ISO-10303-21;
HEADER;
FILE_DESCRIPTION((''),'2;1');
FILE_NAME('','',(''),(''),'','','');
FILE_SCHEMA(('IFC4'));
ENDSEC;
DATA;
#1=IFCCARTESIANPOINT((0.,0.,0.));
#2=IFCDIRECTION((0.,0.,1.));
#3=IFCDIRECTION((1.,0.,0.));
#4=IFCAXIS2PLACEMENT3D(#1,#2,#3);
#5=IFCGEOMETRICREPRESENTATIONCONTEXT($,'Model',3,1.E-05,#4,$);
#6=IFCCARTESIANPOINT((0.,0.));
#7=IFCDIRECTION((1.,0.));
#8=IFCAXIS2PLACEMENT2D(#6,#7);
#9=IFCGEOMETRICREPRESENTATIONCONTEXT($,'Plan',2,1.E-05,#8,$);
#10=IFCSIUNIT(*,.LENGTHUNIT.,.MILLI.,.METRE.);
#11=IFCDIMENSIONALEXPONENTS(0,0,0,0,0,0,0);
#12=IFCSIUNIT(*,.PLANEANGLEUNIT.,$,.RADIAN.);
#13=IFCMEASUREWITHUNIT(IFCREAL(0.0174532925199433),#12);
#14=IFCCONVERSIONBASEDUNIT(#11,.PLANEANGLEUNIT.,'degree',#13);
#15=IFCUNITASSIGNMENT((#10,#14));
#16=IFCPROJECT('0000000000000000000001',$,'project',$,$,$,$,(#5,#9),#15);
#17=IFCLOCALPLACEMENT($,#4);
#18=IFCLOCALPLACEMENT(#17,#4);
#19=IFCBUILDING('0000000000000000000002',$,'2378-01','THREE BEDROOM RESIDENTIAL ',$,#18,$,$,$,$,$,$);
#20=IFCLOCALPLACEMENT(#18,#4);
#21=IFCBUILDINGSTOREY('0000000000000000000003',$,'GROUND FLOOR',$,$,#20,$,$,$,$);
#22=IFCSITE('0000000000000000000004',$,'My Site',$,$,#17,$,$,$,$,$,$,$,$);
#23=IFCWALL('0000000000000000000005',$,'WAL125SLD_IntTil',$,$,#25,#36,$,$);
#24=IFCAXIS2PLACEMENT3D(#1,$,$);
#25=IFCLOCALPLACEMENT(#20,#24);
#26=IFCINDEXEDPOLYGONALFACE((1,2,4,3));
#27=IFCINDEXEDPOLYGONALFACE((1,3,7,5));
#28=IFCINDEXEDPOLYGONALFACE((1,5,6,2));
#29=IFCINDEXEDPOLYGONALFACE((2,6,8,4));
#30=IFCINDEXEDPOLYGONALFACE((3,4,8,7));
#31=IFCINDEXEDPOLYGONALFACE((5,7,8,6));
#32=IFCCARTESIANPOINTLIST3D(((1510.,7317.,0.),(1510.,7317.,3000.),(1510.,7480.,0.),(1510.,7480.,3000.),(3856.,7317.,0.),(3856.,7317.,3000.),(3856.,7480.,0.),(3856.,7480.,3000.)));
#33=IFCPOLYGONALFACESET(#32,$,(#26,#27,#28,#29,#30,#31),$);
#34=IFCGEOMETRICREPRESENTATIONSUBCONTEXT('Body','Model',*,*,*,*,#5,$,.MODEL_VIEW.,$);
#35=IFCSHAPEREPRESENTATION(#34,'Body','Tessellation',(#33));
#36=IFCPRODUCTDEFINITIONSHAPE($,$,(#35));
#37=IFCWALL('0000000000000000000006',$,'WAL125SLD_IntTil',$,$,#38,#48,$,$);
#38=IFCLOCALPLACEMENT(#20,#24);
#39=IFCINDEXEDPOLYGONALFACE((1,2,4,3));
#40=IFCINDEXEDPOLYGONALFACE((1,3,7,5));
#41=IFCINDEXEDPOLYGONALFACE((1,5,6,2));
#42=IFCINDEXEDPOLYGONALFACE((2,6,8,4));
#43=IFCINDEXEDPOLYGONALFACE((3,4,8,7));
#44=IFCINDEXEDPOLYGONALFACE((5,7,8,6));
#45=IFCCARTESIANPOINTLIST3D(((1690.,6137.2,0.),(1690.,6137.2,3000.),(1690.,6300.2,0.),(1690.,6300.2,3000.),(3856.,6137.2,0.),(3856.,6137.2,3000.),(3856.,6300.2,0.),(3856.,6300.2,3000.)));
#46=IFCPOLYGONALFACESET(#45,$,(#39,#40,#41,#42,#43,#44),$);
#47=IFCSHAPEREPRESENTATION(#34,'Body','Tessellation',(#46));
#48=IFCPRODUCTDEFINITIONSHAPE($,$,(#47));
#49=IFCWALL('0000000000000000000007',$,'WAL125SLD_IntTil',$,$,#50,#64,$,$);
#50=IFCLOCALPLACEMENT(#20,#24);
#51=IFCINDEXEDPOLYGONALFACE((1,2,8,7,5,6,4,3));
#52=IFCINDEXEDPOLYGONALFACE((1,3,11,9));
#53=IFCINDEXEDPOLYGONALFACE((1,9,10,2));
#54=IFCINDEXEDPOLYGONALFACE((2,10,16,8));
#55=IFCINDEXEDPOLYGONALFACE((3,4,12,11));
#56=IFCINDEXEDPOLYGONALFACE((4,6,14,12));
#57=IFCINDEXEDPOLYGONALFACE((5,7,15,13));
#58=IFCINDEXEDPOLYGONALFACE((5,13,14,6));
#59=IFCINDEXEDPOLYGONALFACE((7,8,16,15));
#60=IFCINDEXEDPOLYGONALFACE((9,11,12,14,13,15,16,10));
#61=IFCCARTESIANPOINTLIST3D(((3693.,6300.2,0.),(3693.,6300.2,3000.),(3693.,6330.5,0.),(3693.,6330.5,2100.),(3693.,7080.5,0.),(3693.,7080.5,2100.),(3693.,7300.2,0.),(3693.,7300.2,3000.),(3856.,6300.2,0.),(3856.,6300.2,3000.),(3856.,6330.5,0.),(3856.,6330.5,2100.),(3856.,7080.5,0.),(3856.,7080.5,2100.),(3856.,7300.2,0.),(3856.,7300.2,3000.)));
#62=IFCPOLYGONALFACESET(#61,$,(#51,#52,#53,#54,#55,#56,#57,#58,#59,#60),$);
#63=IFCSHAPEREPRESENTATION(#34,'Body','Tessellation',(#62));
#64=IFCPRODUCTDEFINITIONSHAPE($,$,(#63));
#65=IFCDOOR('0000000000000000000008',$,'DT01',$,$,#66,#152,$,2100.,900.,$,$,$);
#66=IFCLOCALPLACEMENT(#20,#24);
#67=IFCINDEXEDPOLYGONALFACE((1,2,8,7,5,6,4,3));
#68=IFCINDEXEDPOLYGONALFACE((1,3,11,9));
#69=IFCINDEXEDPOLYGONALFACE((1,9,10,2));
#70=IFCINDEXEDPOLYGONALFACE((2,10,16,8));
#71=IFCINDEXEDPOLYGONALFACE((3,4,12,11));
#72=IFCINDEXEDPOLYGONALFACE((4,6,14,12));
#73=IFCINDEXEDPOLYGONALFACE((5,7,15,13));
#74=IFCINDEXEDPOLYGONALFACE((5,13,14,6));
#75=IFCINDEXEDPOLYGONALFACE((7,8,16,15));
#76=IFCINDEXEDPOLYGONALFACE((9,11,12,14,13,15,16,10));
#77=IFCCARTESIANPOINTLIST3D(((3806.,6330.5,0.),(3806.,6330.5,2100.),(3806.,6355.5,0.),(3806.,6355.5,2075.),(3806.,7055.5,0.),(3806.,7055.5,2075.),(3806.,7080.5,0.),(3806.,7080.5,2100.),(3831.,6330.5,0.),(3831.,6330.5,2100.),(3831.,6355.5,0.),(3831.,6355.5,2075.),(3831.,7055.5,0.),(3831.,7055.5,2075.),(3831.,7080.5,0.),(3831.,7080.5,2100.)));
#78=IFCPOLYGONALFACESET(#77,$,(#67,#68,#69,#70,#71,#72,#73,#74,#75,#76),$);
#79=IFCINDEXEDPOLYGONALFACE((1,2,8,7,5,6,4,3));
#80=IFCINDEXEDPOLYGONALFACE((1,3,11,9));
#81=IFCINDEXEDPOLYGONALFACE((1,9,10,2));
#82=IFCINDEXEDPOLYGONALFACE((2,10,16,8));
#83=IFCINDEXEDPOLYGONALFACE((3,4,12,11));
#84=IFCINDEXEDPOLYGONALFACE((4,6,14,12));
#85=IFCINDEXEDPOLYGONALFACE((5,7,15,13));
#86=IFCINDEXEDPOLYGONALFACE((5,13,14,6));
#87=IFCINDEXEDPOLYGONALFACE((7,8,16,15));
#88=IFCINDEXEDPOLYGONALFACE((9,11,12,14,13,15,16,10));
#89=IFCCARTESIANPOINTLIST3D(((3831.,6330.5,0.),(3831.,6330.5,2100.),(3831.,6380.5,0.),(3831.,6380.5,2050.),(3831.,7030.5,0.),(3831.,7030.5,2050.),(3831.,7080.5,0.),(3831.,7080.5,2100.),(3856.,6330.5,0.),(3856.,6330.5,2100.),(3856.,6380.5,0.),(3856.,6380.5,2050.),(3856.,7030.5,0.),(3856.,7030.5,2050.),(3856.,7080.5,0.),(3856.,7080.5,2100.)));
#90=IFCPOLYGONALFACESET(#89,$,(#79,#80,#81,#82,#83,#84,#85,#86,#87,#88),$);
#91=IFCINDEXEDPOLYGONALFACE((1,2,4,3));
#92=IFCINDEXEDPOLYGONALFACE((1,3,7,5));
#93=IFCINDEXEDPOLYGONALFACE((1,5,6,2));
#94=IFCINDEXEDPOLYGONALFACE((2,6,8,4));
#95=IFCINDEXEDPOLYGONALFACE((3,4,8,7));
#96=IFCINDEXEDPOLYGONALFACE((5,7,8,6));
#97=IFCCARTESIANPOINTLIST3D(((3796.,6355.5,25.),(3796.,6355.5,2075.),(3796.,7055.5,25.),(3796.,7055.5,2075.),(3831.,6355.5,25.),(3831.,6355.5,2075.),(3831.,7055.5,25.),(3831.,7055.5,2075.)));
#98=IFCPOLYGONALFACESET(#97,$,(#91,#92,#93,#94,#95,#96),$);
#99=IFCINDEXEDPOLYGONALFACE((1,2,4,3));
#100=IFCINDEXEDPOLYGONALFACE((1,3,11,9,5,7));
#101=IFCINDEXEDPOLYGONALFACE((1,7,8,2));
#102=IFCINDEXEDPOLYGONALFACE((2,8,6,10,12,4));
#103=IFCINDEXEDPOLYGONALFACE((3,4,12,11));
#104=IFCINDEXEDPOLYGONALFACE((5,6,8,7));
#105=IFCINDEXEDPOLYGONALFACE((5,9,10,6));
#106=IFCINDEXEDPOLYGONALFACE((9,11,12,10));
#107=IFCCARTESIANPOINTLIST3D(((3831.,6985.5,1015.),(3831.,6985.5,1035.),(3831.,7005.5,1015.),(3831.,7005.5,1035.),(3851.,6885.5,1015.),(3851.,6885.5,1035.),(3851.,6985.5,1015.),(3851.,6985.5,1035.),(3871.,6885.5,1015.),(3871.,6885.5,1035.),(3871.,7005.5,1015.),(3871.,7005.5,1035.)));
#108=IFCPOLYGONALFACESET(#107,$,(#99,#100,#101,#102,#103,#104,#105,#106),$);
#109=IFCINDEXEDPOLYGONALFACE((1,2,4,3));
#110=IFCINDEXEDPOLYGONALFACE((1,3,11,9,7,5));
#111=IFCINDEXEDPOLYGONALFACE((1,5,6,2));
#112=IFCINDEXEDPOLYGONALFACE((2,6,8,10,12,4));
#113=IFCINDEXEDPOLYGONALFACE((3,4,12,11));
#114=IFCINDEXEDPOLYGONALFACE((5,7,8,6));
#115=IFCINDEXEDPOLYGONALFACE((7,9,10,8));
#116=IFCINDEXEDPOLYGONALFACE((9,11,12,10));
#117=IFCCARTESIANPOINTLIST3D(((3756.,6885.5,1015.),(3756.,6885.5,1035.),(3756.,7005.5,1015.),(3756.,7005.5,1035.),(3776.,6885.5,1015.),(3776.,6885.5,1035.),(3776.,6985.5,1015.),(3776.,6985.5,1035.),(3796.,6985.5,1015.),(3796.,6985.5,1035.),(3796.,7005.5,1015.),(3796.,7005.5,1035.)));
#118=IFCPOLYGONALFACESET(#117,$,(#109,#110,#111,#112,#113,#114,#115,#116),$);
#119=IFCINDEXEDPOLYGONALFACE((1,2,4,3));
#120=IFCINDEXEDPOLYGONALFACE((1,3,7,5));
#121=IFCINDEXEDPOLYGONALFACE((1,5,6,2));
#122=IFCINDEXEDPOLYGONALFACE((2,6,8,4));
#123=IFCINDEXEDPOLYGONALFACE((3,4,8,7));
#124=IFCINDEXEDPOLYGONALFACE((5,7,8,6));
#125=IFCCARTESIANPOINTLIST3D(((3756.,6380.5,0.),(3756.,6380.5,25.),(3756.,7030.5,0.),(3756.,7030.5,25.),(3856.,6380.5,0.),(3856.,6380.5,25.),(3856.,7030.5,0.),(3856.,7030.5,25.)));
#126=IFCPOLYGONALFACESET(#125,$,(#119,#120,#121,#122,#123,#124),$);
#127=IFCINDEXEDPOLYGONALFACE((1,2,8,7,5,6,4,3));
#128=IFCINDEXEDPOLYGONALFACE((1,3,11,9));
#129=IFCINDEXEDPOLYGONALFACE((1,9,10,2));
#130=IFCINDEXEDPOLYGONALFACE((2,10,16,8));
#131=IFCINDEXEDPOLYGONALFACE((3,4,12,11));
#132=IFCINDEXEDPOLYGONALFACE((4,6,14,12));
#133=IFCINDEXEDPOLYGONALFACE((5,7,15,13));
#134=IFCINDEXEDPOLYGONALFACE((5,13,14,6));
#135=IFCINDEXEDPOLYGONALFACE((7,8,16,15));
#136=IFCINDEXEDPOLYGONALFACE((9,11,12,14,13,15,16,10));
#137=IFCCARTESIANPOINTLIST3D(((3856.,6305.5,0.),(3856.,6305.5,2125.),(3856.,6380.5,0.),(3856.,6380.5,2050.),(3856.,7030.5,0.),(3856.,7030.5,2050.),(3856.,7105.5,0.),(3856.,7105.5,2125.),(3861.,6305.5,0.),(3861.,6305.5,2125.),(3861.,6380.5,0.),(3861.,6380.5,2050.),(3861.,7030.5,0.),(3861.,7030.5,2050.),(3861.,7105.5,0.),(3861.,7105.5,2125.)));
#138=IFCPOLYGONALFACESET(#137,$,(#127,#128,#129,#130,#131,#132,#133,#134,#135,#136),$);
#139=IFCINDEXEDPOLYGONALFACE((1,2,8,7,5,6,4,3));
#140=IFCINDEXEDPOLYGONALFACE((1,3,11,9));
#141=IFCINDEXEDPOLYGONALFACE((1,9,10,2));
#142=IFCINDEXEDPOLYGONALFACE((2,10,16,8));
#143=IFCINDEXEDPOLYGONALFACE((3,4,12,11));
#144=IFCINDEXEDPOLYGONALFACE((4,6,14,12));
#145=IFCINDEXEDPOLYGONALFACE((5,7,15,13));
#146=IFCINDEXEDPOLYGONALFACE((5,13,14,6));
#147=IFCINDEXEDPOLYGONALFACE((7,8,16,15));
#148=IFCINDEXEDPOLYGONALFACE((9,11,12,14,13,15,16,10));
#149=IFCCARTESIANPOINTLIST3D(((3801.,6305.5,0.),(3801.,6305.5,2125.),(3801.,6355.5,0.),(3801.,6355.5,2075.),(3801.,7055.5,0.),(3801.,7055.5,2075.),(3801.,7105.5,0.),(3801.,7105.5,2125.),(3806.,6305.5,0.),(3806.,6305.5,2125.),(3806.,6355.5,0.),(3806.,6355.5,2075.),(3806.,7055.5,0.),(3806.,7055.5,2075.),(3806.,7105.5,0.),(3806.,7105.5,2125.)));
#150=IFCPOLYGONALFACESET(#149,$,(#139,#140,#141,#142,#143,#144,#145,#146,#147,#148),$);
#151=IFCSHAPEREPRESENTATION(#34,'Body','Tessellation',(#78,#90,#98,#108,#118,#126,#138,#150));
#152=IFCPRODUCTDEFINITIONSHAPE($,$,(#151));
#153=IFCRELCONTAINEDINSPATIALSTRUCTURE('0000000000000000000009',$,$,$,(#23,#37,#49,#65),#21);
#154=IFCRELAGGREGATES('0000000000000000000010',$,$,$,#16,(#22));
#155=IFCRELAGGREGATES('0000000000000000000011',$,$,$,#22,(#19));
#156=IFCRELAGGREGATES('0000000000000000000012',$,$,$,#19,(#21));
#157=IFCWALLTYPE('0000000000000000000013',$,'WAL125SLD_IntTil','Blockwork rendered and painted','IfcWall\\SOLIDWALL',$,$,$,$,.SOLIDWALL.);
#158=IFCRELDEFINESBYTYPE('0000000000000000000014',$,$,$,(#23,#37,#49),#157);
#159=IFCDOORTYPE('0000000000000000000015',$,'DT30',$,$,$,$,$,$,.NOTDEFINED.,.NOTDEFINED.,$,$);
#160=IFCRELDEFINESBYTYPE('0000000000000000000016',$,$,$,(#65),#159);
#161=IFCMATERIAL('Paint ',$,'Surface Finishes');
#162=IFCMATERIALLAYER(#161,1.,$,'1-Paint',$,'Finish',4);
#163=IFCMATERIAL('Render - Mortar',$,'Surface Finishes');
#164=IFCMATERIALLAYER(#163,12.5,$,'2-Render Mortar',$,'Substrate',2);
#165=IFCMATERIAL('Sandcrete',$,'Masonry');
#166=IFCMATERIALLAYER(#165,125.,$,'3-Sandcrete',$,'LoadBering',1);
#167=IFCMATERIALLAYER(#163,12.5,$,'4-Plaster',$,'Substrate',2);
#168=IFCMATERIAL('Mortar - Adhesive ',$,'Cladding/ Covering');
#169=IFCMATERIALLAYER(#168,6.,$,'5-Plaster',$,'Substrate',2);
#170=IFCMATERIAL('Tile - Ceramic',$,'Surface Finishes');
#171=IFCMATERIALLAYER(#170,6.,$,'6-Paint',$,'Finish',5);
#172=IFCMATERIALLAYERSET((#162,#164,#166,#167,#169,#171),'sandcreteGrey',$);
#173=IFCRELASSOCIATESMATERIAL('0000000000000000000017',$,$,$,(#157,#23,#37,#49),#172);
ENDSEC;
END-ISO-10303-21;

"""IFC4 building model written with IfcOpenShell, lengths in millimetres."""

from ifc_helpers import new_model, entity, si_unit, converted_unit, frame, origin_with_axes, origin_2d_with_axis, place, context, subcontext, project, spatial, line, indexed_curve, outline, extrude, shape, source, transform, mapped, material, layer, layer_set, layer_usage, type_object, type_shapes, element, fill, save


model = new_model("IFC4")

# Units and contexts
model_context = context("Model", 3, precision=1e-05, world=origin_with_axes())
plan_context = context("Plan", 2, precision=1e-05, world=origin_2d_with_axis())
body_context_1 = subcontext(model_context, "Body", "Model", "MODEL_VIEW")
body_context_2 = subcontext(plan_context, "Body", "Plan", "PLAN_VIEW")
ifc_project = project(units=[si_unit("LENGTHUNIT", "METRE", prefix="MILLI"), converted_unit("PLANEANGLEUNIT", "degree", entity("IfcReal", 0.0174532925199433), si_unit("PLANEANGLEUNIT", "RADIAN"), dimensions=[0, 0, 0, 0, 0, 0, 0])], contexts=[model_context, plan_context])

# Site, building, storey
site_placement = place(None, origin_with_axes())
site = spatial("IfcSite", under=ifc_project, at=site_placement, Name="My Site")
building_placement = place(site_placement, origin_with_axes())
building = spatial("IfcBuilding", under=site, at=building_placement, Name="2378-01", Description="THREE BEDROOM RESIDENTIAL ")
storey_placement = place(building_placement, origin_with_axes())
storey = spatial("IfcBuildingStorey", under=building, at=storey_placement, Name="GROUND FLOOR")

# Walls
ifc_material_1 = material(Name="Paint ", Category="Surface Finishes")
ifc_layer_1 = layer(ifc_material_1, 1.0, Name="1-Paint", Category="Finish", Priority=4)
ifc_material_2 = material(Name="Render - Mortar", Category="Surface Finishes")
ifc_layer_2 = layer(ifc_material_2, 12.5, Name="2-Render Mortar", Category="Substrate", Priority=2)
ifc_material_3 = material(Name="Sandcrete", Category="Masonry")
ifc_layer_3 = layer(ifc_material_3, 125.0, Name="3-Sandcrete", Category="LoadBering", Priority=1)
ifc_layer_4 = layer(ifc_material_2, 12.5, Name="4-Plaster", Category="Substrate", Priority=2)
ifc_material_4 = material(Name="Mortar - Adhesive ", Category="Cladding/ Covering")
ifc_layer_5 = layer(ifc_material_4, 6.0, Name="5-Plaster", Category="Substrate", Priority=2)
ifc_material_5 = material(Name="Tile - Ceramic", Category="Surface Finishes")
ifc_layer_6 = layer(ifc_material_5, 6.0, Name="6-Paint", Category="Finish", Priority=5)
ifc_layer_set_1 = layer_set([ifc_layer_1, ifc_layer_2, ifc_layer_3, ifc_layer_4, ifc_layer_5, ifc_layer_6], Name="sandcreteGrey")
ifc_layer_usage_1 = layer_usage(ifc_layer_set_1, "AXIS2", "POSITIVE", 0.0)
wall_type_1 = type_object("IfcWallType", Name="WAL125SLD_IntTil", Description="Blockwork rendered and painted", ApplicableOccurrence="IfcWall\\SOLIDWALL", PredefinedType="SOLIDWALL", material=ifc_layer_set_1)
wall_1_placement = place(storey_placement, frame((3856.0, 7480.0, 0.0), z_axis=(0.0, 0.0, 1.0), x_axis=(-1.0, 0.0, 0.0)))
element("IfcWall", 1, at=wall_1_placement, inside=storey, type_object=wall_type_1, material=ifc_layer_usage_1, Name="WAL125SLD_IntTil", context=body_context_1, shape_type="SweptSolid", body=[
    extrude(outline(indexed_curve([(0.0, 0.0), (0.0, 163.0), (2346.0, 163.0), (2346.0, 0.0), (0.0, 0.0)], self_intersect=False)), origin_with_axes(), (0.0, 0.0, 1.0), 3000.0),
])
ifc_layer_usage_2 = layer_usage(ifc_layer_set_1, "AXIS2", "POSITIVE", 0.0)
wall_2_placement = place(storey_placement, frame((1690.0, 6137.2, 0.0), z_axis=(0.0, 0.0, 1.0), x_axis=(1.0, 0.0, 0.0)))
element("IfcWall", 2, at=wall_2_placement, inside=storey, type_object=wall_type_1, material=ifc_layer_usage_2, Name="WAL125SLD_IntTil", context=body_context_1, shape_type="SweptSolid", body=[
    extrude(outline(indexed_curve([(0.0, 0.0), (0.0, 163.0), (2166.0, 163.0), (2166.0, 0.0), (0.0, 0.0)], self_intersect=False)), origin_with_axes(), (0.0, 0.0, 1.0), 3000.0),
])

# Wall, opening, door
ifc_layer_usage_3 = layer_usage(ifc_layer_set_1, "AXIS2", "POSITIVE", 0.0)
wall_3_placement = place(storey_placement, frame((3856.0, 6300.2, 0.0), z_axis=(0.0, 0.0, 1.0), x_axis=(0.0, 1.0, 0.0)))
wall_3 = element("IfcWall", 3, at=wall_3_placement, inside=storey, type_object=wall_type_1, material=ifc_layer_usage_3, Name="WAL125SLD_IntTil", context=body_context_1, shape_type="SweptSolid", body=[
    extrude(outline(indexed_curve([(0.0, 0.0), (0.0, 163.0), (1000.0, 163.0), (1000.0, 0.0), (0.0, 0.0)], self_intersect=False)), origin_with_axes(), (0.0, 0.0, 1.0), 3000.0),
])
shared_shape_1 = source(origin_with_axes(), body_context_1, "Body", "SweptSolid", [
    extrude(outline(indexed_curve([(0.0, 0.0), (750.0, 0.0), (750.0, 2100.0), (0.0, 2100.0)], segments=[line(1, 2, 3, 4, 1)])), frame((0.0, -100.0, 0.0), z_axis=(0.0, -1.0, 0.0), x_axis=(1.0, 0.0, 0.0)), (0.0, 0.0, -1.0), 380.0),
])
opening_1_placement = place(wall_3_placement, frame((30.4, 0.0, 0.0), z_axis=(0.0, 0.0, 1.0), x_axis=(1.0, 0.0, 0.0)))
opening_1 = element("IfcOpeningElement", 4, at=opening_1_placement, cuts=wall_3, PredefinedType="OPENING", context=body_context_1, shape_type="MappedRepresentation", body=[
    mapped(shared_shape_1, transform((0.0, 0.0, 0.0), x_axis=(1.0, 0.0, 0.0), y_axis=(0.0, 1.0, 0.0), z_axis=(0.0, 0.0, 1.0), scale=1.0)),
])
door_type = type_object("IfcDoorType", Name="DT30", OperationType="NOTDEFINED", PredefinedType="NOTDEFINED")
shared_shape_2 = source(origin_with_axes(), body_context_1, "Body", "SweptSolid", [
    extrude(outline(indexed_curve([(0.0, 0.0), (0.0, 2100.0), (750.0, 2100.0), (750.0, 0.0), (725.0, 0.0), (725.0, 2075.0), (25.0, 2075.0), (25.0, 0.0)], segments=[line(1, 2, 3, 4, 5, 6, 7, 8, 1)])), frame((0.0, 25.0, 0.0), z_axis=(0.0, -1.0, 0.0), x_axis=(1.0, 0.0, 0.0)), (0.0, 0.0, -1.0), 25.0),
    extrude(outline(indexed_curve([(0.0, 0.0), (0.0, 2100.0), (750.0, 2100.0), (750.0, 0.0), (700.0, 0.0), (700.0, 2050.0), (50.0, 2050.0), (50.0, 0.0)], segments=[line(1, 2, 3, 4, 5, 6, 7, 8, 1)])), frame((0.0, 0.0, 0.0), z_axis=(0.0, -1.0, 0.0), x_axis=(1.0, 0.0, 0.0)), (0.0, 0.0, -1.0), 25.0),
    extrude(outline(indexed_curve([(0.0, 0.0), (700.0, 0.0), (700.0, 35.0), (0.0, 35.0)], segments=[line(1, 2, 3, 4, 1)])), frame((25.0, 25.0, 25.0), z_axis=(0.0, 0.0, 1.0), x_axis=(1.0, 0.0, 0.0)), (0.0, 0.0, 1.0), 2050.0),
    extrude(outline(indexed_curve([(0.0, 0.0), (0.0, -40.0), (-120.0, -40.0), (-120.0, -20.0), (-20.0, -20.0), (-20.0, 0.0)], segments=[line(1, 2, 3, 4, 5, 6, 1)])), frame((675.0, 25.0, 1015.0), z_axis=(0.0, 0.0, 1.0), x_axis=(1.0, 0.0, 0.0)), (0.0, 0.0, 1.0), 20.0),
    extrude(outline(indexed_curve([(0.0, 0.0), (0.0, 40.0), (-120.0, 40.0), (-120.0, 20.0), (-20.0, 20.0), (-20.0, 0.0)], segments=[line(1, 2, 3, 4, 5, 6, 1)])), frame((675.0, 60.0, 1015.0), z_axis=(0.0, 0.0, 1.0), x_axis=(1.0, 0.0, 0.0)), (0.0, 0.0, 1.0), 20.0),
    extrude(outline(indexed_curve([(0.0, 0.0), (650.0, 0.0), (650.0, 100.0), (0.0, 100.0)], segments=[line(1, 2, 3, 4, 1)])), frame((50.0, 0.0, 0.0), z_axis=(0.0, 0.0, 1.0), x_axis=(1.0, 0.0, 0.0)), (0.0, 0.0, 1.0), 25.0),
    extrude(outline(indexed_curve([(0.0, 0.0), (0.0, 2125.0), (800.0, 2125.0), (800.0, 0.0), (725.0, 0.0), (725.0, 2050.0), (75.0, 2050.0), (75.0, 0.0)], segments=[line(1, 2, 3, 4, 5, 6, 7, 8, 1)])), frame((-25.0, -5.0, 0.0), z_axis=(0.0, -1.0, 0.0), x_axis=(1.0, 0.0, 0.0)), (0.0, 0.0, -1.0), 5.0),
    extrude(outline(indexed_curve([(0.0, 0.0), (0.0, 2125.0), (800.0, 2125.0), (800.0, 0.0), (750.0, 0.0), (750.0, 2075.0), (50.0, 2075.0), (50.0, 0.0)], segments=[line(1, 2, 3, 4, 5, 6, 7, 8, 1)])), frame((-25.0, 50.0, 0.0), z_axis=(0.0, -1.0, 0.0), x_axis=(1.0, 0.0, 0.0)), (0.0, 0.0, -1.0), 5.0),
])
shared_shape_3 = source(origin_with_axes(), body_context_2, "Body", "Curve2D", [
    entity("IfcIndexedPolyCurve", entity("IfcCartesianPointList2D", [[0.0, 0.0], [0.0, 50.0], [25.0, 50.0], [25.0, 25.0], [50.0, 25.0], [50.0, 0.0]]), [entity("IfcLineIndex", [1, 2, 3, 4, 5, 6, 1])]),
    entity("IfcIndexedPolyCurve", entity("IfcCartesianPointList2D", [[750.0, 0.0], [750.0, 50.0], [725.0, 50.0], [725.0, 25.0], [700.0, 25.0], [700.0, 0.0]]), [entity("IfcLineIndex", [1, 2, 3, 4, 5, 6, 1])]),
    entity("IfcTrimmedCurve", entity("IfcEllipse", entity("IfcAxis2Placement2D", entity("IfcCartesianPoint", [60.0, 50.0]), entity("IfcDirection", [1.0, 0.0])), 665.0, 700.0), [entity("IfcCartesianPoint", [725.0, 50.0])], [entity("IfcCartesianPoint", [60.0, 750.0])], True, "CARTESIAN"),
    entity("IfcIndexedPolyCurve", entity("IfcCartesianPointList2D", [[25.0, 50.0], [60.0, 50.0], [60.0, 750.0], [25.0, 750.0]]), [entity("IfcLineIndex", [1, 2, 3, 4, 1])]),
])
type_shapes(door_type, [shared_shape_2, shared_shape_3])
door_placement = place(opening_1_placement, frame((0.0, 0.0, 0.0), z_axis=(0.0, 0.0, 1.0), x_axis=(1.0, 0.0, 0.0)))
door = element("IfcDoor", 5, at=door_placement, inside=storey, type_object=door_type, Name="DT01", OverallHeight=2100.0, OverallWidth=900.0, shapes=[
    shape(body_context_1, "Body", "MappedRepresentation", [mapped(shared_shape_2, transform((0.0, 0.0, 0.0), x_axis=(1.0, 0.0, 0.0), y_axis=(0.0, 1.0, 0.0), z_axis=(0.0, 0.0, 1.0), scale=1.0))]),
    shape(body_context_2, "Body", "MappedRepresentation", [mapped(shared_shape_3, transform((0.0, 0.0, 0.0), x_axis=(1.0, 0.0, 0.0), y_axis=(0.0, 1.0, 0.0), z_axis=(0.0, 0.0, 1.0), scale=1.0))]),
])
fill(opening_1, door)

save(model, "model.ifc")
